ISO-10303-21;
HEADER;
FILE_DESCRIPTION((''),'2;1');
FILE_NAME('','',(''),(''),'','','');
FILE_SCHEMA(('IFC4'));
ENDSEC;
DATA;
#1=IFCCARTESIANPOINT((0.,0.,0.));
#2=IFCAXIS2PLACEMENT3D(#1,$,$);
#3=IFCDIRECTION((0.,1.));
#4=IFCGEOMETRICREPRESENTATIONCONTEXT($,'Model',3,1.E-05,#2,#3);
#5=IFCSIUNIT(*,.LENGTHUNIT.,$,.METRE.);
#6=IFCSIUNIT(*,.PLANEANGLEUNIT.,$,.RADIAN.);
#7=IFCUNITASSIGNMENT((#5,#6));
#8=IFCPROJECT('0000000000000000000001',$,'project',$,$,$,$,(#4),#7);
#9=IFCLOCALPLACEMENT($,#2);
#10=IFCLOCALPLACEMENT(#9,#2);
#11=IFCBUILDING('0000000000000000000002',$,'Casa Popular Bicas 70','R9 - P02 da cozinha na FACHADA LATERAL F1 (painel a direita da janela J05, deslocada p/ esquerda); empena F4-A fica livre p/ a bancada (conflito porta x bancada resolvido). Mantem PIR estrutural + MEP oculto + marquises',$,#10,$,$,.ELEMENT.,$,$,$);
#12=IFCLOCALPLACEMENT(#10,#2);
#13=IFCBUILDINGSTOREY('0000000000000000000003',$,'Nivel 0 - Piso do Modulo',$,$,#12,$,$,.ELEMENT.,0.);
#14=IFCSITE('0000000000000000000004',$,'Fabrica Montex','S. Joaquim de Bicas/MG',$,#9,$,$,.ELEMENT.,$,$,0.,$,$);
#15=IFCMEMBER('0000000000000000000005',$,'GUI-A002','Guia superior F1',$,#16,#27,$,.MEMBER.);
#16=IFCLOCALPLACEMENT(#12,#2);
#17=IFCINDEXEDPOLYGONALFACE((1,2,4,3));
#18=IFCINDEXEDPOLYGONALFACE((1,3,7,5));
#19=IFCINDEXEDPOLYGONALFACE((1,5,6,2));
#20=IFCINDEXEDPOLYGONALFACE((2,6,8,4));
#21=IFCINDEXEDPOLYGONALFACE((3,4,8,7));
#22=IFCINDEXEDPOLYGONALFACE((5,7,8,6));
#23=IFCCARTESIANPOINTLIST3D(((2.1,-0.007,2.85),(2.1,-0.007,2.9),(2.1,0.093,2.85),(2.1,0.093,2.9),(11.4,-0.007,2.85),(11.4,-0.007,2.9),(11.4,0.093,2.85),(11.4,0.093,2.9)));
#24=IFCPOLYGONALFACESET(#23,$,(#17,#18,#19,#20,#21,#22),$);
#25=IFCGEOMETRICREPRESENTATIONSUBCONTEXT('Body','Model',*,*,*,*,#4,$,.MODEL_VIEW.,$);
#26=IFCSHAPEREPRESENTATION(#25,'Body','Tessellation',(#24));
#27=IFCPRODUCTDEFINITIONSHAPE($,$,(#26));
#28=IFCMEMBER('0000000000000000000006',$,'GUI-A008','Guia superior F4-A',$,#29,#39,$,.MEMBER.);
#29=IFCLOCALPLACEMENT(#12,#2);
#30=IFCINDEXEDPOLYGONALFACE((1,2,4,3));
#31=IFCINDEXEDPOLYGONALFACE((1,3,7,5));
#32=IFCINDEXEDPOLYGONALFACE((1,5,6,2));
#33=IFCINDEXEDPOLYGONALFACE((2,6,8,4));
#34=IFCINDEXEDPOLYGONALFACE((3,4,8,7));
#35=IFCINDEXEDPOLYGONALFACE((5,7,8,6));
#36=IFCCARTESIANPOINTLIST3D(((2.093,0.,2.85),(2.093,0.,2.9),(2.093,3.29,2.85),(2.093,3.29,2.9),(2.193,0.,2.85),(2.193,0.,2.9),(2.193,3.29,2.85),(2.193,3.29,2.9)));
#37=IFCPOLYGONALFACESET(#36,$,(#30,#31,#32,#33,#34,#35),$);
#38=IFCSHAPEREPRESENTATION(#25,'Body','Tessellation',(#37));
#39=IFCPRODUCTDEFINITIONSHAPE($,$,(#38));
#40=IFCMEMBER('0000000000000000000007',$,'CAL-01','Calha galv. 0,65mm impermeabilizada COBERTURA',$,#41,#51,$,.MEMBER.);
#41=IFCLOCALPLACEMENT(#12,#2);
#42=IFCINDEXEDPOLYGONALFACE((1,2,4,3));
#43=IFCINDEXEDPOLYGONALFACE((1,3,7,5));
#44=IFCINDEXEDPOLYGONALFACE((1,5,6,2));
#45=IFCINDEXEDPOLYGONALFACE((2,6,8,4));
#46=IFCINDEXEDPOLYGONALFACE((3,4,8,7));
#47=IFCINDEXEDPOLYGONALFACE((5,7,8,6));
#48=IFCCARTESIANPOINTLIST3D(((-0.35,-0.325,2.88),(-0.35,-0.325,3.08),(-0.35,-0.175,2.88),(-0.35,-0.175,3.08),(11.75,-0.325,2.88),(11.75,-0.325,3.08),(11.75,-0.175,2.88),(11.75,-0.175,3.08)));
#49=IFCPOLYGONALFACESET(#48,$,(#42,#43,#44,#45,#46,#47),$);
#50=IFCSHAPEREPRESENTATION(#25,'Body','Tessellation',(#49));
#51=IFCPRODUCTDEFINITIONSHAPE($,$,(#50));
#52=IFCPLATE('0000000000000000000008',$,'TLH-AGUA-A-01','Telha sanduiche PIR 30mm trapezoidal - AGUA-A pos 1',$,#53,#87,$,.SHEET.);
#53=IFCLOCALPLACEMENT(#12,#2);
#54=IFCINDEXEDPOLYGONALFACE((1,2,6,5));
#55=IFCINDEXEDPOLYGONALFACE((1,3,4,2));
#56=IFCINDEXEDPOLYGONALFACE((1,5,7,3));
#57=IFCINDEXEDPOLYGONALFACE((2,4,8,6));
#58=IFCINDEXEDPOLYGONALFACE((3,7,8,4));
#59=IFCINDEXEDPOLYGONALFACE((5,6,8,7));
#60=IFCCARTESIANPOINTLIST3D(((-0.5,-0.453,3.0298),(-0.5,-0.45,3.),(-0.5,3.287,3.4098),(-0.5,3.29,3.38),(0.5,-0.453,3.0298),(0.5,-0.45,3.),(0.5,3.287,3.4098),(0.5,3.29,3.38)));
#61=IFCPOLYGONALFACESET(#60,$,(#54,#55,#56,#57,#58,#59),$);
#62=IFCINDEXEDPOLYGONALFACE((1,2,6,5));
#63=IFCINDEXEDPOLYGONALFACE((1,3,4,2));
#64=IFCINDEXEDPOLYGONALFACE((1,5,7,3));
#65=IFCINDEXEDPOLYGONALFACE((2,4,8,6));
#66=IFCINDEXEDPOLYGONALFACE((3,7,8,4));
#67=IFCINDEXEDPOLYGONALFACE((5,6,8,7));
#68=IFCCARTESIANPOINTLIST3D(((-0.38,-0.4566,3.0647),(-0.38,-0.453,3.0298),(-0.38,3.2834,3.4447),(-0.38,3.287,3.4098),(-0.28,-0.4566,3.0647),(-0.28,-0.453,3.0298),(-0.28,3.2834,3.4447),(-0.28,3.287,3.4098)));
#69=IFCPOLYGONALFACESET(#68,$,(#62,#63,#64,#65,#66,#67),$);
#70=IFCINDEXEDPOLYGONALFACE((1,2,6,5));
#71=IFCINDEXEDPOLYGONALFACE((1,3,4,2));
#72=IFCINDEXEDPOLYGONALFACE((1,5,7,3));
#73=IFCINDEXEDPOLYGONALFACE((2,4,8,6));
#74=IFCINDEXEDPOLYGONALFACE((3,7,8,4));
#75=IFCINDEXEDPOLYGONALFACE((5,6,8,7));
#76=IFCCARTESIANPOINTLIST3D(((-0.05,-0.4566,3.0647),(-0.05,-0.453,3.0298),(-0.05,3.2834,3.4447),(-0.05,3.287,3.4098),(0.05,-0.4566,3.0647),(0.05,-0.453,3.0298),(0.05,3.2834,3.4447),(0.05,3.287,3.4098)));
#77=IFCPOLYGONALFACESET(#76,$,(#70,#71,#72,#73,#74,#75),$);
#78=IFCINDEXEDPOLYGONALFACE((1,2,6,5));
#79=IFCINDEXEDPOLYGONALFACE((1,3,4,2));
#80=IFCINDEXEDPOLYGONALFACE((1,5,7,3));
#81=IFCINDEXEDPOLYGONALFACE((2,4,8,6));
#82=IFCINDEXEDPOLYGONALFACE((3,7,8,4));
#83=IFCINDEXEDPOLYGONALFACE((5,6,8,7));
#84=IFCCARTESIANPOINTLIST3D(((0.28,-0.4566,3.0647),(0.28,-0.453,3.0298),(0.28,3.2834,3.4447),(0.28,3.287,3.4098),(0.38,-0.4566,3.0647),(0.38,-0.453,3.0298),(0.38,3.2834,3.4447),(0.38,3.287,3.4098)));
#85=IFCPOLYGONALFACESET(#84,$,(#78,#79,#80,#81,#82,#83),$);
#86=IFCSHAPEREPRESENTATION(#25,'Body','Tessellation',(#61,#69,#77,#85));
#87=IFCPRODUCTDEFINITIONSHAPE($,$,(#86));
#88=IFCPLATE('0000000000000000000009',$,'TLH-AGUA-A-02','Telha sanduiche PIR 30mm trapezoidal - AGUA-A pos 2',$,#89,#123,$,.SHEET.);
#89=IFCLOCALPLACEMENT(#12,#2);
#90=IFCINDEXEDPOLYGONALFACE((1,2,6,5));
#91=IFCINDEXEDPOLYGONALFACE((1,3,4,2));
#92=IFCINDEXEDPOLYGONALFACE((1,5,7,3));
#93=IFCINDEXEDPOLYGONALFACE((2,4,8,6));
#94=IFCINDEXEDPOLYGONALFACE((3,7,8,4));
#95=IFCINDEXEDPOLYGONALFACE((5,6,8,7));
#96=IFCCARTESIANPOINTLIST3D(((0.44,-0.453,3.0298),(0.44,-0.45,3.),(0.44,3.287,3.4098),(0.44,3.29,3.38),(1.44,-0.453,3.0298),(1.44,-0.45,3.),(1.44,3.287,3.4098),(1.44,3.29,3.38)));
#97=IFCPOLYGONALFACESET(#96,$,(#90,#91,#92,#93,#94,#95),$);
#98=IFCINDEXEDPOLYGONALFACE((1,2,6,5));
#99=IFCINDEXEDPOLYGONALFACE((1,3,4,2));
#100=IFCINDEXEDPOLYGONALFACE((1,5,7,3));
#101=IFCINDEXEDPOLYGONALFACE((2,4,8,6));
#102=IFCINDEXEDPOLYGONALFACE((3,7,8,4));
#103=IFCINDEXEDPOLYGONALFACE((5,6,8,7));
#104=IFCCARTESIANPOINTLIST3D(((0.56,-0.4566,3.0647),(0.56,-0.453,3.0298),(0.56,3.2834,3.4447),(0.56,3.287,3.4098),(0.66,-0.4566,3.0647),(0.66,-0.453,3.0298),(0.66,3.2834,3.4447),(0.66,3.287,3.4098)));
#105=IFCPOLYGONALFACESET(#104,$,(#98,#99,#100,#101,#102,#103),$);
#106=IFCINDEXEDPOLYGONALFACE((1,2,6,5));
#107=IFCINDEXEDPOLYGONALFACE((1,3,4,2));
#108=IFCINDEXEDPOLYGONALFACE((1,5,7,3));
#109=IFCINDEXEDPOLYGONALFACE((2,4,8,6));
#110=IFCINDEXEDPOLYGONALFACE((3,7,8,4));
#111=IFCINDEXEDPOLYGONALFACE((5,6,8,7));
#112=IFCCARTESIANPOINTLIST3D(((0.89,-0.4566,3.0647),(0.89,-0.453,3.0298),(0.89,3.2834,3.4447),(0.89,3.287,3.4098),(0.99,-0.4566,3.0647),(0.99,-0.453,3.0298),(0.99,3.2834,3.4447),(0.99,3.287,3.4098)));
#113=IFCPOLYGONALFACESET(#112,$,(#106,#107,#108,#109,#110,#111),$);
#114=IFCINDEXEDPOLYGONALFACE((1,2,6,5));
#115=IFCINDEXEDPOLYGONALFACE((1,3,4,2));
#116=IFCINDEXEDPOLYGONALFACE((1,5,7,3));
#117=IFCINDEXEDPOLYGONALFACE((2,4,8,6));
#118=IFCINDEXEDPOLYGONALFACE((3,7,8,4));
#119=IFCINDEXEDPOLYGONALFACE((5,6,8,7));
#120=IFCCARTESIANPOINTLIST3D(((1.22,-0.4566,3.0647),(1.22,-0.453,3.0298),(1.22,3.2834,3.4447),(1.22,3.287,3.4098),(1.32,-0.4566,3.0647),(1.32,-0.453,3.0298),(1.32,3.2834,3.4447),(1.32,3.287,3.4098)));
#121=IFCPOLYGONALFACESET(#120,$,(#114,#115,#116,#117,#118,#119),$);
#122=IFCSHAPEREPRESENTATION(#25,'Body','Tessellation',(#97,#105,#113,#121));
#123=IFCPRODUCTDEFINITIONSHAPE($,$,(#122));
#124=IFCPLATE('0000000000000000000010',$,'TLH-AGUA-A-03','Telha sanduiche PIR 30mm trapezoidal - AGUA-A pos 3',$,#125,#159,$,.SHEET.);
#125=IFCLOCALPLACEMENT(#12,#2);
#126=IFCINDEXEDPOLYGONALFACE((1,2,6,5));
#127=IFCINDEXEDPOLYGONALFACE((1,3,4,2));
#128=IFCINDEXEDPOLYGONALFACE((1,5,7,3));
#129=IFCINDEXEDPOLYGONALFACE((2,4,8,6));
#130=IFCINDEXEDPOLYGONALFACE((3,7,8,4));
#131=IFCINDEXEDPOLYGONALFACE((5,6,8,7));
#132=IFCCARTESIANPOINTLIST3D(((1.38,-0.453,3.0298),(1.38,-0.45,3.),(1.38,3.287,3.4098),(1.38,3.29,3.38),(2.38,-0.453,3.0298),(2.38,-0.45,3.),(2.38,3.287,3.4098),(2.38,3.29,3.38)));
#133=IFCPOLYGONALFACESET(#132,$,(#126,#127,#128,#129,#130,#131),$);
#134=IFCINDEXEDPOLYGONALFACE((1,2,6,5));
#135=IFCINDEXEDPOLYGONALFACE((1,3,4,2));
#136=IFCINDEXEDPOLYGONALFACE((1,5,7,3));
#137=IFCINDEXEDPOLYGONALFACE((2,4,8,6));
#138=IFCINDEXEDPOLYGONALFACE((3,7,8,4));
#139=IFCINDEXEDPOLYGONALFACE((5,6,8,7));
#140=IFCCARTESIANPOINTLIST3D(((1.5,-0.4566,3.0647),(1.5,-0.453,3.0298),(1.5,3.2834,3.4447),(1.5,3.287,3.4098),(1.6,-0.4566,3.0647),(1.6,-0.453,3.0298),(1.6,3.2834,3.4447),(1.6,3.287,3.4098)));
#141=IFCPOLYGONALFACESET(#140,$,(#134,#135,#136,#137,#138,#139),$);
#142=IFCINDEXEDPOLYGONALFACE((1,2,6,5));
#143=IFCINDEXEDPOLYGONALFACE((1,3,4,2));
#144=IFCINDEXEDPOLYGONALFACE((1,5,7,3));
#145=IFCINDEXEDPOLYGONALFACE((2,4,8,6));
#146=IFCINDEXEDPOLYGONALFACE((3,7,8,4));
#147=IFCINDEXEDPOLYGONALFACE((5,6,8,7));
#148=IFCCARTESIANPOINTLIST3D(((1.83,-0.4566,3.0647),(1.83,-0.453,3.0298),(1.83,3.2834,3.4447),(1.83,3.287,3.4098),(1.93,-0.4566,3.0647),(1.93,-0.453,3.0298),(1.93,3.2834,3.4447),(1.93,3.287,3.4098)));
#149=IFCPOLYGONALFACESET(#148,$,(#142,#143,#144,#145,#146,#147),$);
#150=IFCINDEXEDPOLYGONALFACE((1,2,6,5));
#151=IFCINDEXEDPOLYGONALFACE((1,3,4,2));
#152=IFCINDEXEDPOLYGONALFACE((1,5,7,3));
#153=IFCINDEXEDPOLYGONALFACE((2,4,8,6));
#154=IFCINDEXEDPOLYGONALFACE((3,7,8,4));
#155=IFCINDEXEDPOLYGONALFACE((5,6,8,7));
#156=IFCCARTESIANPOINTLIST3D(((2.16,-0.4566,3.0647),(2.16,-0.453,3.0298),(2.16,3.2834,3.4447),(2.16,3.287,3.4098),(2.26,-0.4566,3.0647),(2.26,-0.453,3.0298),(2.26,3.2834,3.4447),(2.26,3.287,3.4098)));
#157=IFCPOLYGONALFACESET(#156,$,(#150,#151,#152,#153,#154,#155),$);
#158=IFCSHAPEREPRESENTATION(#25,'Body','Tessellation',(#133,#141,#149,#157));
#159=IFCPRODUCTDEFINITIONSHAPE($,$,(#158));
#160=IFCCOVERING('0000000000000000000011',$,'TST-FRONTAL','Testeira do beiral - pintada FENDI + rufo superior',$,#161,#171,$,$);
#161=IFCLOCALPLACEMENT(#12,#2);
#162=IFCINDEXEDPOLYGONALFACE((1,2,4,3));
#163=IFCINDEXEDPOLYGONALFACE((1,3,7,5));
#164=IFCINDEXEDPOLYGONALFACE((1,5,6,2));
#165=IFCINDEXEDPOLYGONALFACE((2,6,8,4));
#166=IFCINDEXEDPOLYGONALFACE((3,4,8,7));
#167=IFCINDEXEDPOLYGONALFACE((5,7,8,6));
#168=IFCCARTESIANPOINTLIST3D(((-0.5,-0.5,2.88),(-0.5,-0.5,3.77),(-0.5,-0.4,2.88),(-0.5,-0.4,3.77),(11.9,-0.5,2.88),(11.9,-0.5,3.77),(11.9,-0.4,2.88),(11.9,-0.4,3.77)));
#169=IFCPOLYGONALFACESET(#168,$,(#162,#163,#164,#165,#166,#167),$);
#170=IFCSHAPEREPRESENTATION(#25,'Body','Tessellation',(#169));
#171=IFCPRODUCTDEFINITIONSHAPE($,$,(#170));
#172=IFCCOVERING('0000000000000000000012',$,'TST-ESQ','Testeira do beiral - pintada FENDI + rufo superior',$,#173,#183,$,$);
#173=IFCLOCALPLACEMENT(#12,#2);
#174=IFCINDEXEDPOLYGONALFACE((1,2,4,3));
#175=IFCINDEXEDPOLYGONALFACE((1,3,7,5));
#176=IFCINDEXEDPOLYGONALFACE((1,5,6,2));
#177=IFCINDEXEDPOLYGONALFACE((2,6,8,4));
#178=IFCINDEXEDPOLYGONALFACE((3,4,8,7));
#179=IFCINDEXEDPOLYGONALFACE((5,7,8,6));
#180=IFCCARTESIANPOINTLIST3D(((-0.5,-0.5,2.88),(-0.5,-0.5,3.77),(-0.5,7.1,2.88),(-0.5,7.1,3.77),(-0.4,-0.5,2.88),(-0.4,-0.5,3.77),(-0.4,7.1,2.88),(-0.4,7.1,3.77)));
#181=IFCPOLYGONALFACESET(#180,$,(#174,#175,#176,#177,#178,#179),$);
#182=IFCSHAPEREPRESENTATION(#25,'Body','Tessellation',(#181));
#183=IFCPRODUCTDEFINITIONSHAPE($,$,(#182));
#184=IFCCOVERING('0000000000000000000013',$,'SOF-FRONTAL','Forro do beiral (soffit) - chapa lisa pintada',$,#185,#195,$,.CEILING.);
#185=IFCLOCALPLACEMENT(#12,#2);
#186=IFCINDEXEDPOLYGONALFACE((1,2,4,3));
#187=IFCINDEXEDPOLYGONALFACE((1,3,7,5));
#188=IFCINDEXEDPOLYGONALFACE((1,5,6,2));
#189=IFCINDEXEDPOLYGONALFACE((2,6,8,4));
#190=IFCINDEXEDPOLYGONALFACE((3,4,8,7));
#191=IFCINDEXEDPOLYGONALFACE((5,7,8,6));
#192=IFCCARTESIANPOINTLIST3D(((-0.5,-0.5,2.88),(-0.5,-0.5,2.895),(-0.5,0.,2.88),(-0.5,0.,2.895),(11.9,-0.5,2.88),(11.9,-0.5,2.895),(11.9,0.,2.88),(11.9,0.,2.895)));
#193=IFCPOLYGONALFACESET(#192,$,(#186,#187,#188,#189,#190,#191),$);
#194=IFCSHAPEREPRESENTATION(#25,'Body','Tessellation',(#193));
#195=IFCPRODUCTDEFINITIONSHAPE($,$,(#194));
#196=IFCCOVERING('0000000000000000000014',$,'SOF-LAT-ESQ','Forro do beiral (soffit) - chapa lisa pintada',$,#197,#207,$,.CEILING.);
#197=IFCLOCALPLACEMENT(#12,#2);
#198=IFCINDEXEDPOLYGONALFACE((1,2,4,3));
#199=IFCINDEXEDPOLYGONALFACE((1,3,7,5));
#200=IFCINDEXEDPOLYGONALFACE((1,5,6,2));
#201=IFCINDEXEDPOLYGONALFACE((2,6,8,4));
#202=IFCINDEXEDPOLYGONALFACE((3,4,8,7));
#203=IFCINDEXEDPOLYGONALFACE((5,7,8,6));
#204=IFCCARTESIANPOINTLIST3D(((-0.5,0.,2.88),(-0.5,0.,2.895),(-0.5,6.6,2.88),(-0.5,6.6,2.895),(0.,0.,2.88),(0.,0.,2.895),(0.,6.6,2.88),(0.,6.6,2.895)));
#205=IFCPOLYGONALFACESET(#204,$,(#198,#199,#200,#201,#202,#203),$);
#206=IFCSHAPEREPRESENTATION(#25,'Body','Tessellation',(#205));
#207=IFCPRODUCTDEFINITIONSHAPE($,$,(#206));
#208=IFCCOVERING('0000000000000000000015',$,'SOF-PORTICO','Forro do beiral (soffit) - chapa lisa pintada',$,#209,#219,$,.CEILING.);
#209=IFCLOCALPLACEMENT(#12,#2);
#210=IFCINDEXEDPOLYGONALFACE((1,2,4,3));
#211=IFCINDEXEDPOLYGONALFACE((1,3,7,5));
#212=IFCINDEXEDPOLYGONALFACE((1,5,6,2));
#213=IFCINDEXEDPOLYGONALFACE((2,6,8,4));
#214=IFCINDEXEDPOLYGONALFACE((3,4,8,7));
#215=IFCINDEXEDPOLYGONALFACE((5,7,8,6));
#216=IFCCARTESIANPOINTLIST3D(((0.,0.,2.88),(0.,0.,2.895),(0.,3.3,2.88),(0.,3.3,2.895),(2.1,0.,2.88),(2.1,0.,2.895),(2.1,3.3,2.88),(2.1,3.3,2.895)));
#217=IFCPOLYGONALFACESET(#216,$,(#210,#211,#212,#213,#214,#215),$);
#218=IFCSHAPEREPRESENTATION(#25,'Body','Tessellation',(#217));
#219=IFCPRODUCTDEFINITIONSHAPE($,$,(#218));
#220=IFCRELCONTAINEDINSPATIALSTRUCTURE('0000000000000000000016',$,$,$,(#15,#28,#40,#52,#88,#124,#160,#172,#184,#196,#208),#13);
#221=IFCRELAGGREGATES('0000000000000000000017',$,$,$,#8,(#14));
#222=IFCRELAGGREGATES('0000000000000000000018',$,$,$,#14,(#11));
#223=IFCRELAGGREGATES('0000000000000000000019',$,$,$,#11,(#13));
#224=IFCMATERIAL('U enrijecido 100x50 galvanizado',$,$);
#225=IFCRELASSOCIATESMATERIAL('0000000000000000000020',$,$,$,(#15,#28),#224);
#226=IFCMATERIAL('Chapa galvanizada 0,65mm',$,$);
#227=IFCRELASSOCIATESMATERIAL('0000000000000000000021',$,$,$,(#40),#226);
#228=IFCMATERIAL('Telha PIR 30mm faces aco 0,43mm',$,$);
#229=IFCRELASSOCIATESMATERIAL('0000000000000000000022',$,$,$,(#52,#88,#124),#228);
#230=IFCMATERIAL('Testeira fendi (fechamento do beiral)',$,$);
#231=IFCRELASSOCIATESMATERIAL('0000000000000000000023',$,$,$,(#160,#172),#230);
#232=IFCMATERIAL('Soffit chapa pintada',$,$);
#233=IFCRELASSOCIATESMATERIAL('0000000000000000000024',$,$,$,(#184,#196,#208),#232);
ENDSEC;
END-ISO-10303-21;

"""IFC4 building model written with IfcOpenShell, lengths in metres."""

from ifc_helpers import new_model, si_unit, direction, frame, frame_2d, origin, origin_2d, place, context, subcontext, project, spatial, rectangle, extrude, material, element, save


model = new_model("IFC4")

# Units and contexts
model_context = context("Model", 3, precision=1e-05, world=origin(), true_north=direction((0.0, 1.0)))
body_context = subcontext(model_context, "Body", "Model", "MODEL_VIEW")
ifc_project = project(units=[si_unit("LENGTHUNIT", "METRE"), si_unit("PLANEANGLEUNIT", "RADIAN")], contexts=[model_context])

# Site, building, storey
site_placement = place(None, origin())
site = spatial("IfcSite", under=ifc_project, at=site_placement, Name="Fabrica Montex", Description="S. Joaquim de Bicas/MG", CompositionType="ELEMENT", RefElevation=0.0)
building_placement = place(site_placement, origin())
building = spatial("IfcBuilding", under=site, at=building_placement, Name="Casa Popular Bicas 70", Description="R9 - P02 da cozinha na FACHADA LATERAL F1 (painel a direita da janela J05, deslocada p/ esquerda); empena F4-A fica livre p/ a bancada (conflito porta x bancada resolvido). Mantem PIR estrutural + MEP oculto + marquises", CompositionType="ELEMENT")
storey_placement = place(building_placement, origin())
storey = spatial("IfcBuildingStorey", under=building, at=storey_placement, Name="Nivel 0 - Piso do Modulo", CompositionType="ELEMENT", Elevation=0.0)

# Members
ifc_material_1 = material(Name="U enrijecido 100x50 galvanizado")
member_1_placement = place(storey_placement, frame((2.1, 0.043, 2.875), z_axis=(1.0, 0.0, 0.0), x_axis=(0.0, 0.0, 1.0)))
element("IfcMember", 1, at=member_1_placement, inside=storey, material=ifc_material_1, Name="GUI-A002", Description="Guia superior F1", PredefinedType="MEMBER", context=body_context, shape_type="SweptSolid", body=[
    extrude(rectangle(XDim=0.05, YDim=0.1, at=origin_2d()), origin(), (0.0, 0.0, 1.0), 9.3),
])
member_2_placement = place(storey_placement, frame((2.143, 0.0, 2.875), z_axis=(0.0, 1.0, 0.0), x_axis=(0.0, 0.0, 1.0)))
element("IfcMember", 2, at=member_2_placement, inside=storey, material=ifc_material_1, Name="GUI-A008", Description="Guia superior F4-A", PredefinedType="MEMBER", context=body_context, shape_type="SweptSolid", body=[
    extrude(rectangle(XDim=0.05, YDim=0.1, at=origin_2d()), origin(), (0.0, 0.0, 1.0), 3.29),
])
ifc_material_2 = material(Name="Chapa galvanizada 0,65mm")
member_3_placement = place(storey_placement, frame((-0.35, -0.25, 2.98), z_axis=(1.0, 0.0, 0.0), x_axis=(0.0, 0.0, 1.0)))
element("IfcMember", 3, at=member_3_placement, inside=storey, material=ifc_material_2, Name="CAL-01", Description="Calha galv. 0,65mm impermeabilizada COBERTURA", PredefinedType="MEMBER", context=body_context, shape_type="SweptSolid", body=[
    extrude(rectangle(XDim=0.2, YDim=0.15, at=origin_2d()), origin(), (0.0, 0.0, 1.0), 12.1),
])

# Plates
ifc_material_3 = material(Name="Telha PIR 30mm faces aco 0,43mm")
for number, where, z_axis, x_axis, name, description in (
    (4, (-0.5, -0.45, 3.0), (0.0, -0.101084, 0.994878), (1.0, 0.0, 0.0), "TLH-AGUA-A-01", "Telha sanduiche PIR 30mm trapezoidal - AGUA-A pos 1"),
    (5, (0.44, -0.45, 3.0), (0.0, -0.101084, 0.994878), (1.0, 0.0, 0.0), "TLH-AGUA-A-02", "Telha sanduiche PIR 30mm trapezoidal - AGUA-A pos 2"),
    (6, (1.38, -0.45, 3.0), (0.0, -0.101084, 0.994878), (1.0, 0.0, 0.0), "TLH-AGUA-A-03", "Telha sanduiche PIR 30mm trapezoidal - AGUA-A pos 3"),
):
    element("IfcPlate", number, at=place(storey_placement, frame(where, z_axis=z_axis, x_axis=x_axis)), inside=storey, material=ifc_material_3, Name=name, Description=description, PredefinedType="SHEET", context=body_context, shape_type="SweptSolid", body=[
        extrude(rectangle(XDim=1.0, YDim=3.7593, at=frame_2d((0.5, 1.8796))), origin(), (0.0, 0.0, 1.0), 0.03),
        extrude(rectangle(XDim=0.1, YDim=3.7593, at=frame_2d((0.17, 1.8796))), frame((0.0, 0.0, 0.03)), (0.0, 0.0, 1.0), 0.035),
        extrude(rectangle(XDim=0.1, YDim=3.7593, at=frame_2d((0.5, 1.8796))), frame((0.0, 0.0, 0.03)), (0.0, 0.0, 1.0), 0.035),
        extrude(rectangle(XDim=0.1, YDim=3.7593, at=frame_2d((0.83, 1.8796))), frame((0.0, 0.0, 0.03)), (0.0, 0.0, 1.0), 0.035),
    ])

# Coverings
ifc_material_4 = material(Name="Testeira fendi (fechamento do beiral)")
covering_1_placement = place(storey_placement, frame((-0.5, -0.45, 2.88), x_axis=(1.0, 0.0, 0.0)))
element("IfcCovering", 7, at=covering_1_placement, inside=storey, material=ifc_material_4, Name="TST-FRONTAL", Description="Testeira do beiral - pintada FENDI + rufo superior", context=body_context, shape_type="SweptSolid", body=[
    extrude(rectangle(XDim=12.4, YDim=0.1, at=frame_2d((6.2, 0.0))), origin(), (0.0, 0.0, 1.0), 0.89),
])
covering_2_placement = place(storey_placement, frame((-0.45, -0.5, 2.88), x_axis=(0.0, 1.0, 0.0)))
element("IfcCovering", 8, at=covering_2_placement, inside=storey, material=ifc_material_4, Name="TST-ESQ", Description="Testeira do beiral - pintada FENDI + rufo superior", context=body_context, shape_type="SweptSolid", body=[
    extrude(rectangle(XDim=7.6, YDim=0.1, at=frame_2d((3.8, 0.0))), origin(), (0.0, 0.0, 1.0), 0.89),
])
ifc_material_5 = material(Name="Soffit chapa pintada")
covering_3_placement = place(storey_placement, frame((-0.5, -0.5, 2.88)))
element("IfcCovering", 9, at=covering_3_placement, inside=storey, material=ifc_material_5, Name="SOF-FRONTAL", Description="Forro do beiral (soffit) - chapa lisa pintada", PredefinedType="CEILING", context=body_context, shape_type="SweptSolid", body=[
    extrude(rectangle(XDim=12.4, YDim=0.5, at=frame_2d((6.2, 0.25))), origin(), (0.0, 0.0, 1.0), 0.015),
])
covering_4_placement = place(storey_placement, frame((-0.5, 0.0, 2.88)))
element("IfcCovering", 10, at=covering_4_placement, inside=storey, material=ifc_material_5, Name="SOF-LAT-ESQ", Description="Forro do beiral (soffit) - chapa lisa pintada", PredefinedType="CEILING", context=body_context, shape_type="SweptSolid", body=[
    extrude(rectangle(XDim=0.5, YDim=6.6, at=frame_2d((0.25, 3.3))), origin(), (0.0, 0.0, 1.0), 0.015),
])
covering_5_placement = place(storey_placement, frame((0.0, 0.0, 2.88)))
element("IfcCovering", 11, at=covering_5_placement, inside=storey, material=ifc_material_5, Name="SOF-PORTICO", Description="Forro do beiral (soffit) - chapa lisa pintada", PredefinedType="CEILING", context=body_context, shape_type="SweptSolid", body=[
    extrude(rectangle(XDim=2.1, YDim=3.3, at=frame_2d((1.05, 1.65))), origin(), (0.0, 0.0, 1.0), 0.015),
])

save(model, "model.ifc")
